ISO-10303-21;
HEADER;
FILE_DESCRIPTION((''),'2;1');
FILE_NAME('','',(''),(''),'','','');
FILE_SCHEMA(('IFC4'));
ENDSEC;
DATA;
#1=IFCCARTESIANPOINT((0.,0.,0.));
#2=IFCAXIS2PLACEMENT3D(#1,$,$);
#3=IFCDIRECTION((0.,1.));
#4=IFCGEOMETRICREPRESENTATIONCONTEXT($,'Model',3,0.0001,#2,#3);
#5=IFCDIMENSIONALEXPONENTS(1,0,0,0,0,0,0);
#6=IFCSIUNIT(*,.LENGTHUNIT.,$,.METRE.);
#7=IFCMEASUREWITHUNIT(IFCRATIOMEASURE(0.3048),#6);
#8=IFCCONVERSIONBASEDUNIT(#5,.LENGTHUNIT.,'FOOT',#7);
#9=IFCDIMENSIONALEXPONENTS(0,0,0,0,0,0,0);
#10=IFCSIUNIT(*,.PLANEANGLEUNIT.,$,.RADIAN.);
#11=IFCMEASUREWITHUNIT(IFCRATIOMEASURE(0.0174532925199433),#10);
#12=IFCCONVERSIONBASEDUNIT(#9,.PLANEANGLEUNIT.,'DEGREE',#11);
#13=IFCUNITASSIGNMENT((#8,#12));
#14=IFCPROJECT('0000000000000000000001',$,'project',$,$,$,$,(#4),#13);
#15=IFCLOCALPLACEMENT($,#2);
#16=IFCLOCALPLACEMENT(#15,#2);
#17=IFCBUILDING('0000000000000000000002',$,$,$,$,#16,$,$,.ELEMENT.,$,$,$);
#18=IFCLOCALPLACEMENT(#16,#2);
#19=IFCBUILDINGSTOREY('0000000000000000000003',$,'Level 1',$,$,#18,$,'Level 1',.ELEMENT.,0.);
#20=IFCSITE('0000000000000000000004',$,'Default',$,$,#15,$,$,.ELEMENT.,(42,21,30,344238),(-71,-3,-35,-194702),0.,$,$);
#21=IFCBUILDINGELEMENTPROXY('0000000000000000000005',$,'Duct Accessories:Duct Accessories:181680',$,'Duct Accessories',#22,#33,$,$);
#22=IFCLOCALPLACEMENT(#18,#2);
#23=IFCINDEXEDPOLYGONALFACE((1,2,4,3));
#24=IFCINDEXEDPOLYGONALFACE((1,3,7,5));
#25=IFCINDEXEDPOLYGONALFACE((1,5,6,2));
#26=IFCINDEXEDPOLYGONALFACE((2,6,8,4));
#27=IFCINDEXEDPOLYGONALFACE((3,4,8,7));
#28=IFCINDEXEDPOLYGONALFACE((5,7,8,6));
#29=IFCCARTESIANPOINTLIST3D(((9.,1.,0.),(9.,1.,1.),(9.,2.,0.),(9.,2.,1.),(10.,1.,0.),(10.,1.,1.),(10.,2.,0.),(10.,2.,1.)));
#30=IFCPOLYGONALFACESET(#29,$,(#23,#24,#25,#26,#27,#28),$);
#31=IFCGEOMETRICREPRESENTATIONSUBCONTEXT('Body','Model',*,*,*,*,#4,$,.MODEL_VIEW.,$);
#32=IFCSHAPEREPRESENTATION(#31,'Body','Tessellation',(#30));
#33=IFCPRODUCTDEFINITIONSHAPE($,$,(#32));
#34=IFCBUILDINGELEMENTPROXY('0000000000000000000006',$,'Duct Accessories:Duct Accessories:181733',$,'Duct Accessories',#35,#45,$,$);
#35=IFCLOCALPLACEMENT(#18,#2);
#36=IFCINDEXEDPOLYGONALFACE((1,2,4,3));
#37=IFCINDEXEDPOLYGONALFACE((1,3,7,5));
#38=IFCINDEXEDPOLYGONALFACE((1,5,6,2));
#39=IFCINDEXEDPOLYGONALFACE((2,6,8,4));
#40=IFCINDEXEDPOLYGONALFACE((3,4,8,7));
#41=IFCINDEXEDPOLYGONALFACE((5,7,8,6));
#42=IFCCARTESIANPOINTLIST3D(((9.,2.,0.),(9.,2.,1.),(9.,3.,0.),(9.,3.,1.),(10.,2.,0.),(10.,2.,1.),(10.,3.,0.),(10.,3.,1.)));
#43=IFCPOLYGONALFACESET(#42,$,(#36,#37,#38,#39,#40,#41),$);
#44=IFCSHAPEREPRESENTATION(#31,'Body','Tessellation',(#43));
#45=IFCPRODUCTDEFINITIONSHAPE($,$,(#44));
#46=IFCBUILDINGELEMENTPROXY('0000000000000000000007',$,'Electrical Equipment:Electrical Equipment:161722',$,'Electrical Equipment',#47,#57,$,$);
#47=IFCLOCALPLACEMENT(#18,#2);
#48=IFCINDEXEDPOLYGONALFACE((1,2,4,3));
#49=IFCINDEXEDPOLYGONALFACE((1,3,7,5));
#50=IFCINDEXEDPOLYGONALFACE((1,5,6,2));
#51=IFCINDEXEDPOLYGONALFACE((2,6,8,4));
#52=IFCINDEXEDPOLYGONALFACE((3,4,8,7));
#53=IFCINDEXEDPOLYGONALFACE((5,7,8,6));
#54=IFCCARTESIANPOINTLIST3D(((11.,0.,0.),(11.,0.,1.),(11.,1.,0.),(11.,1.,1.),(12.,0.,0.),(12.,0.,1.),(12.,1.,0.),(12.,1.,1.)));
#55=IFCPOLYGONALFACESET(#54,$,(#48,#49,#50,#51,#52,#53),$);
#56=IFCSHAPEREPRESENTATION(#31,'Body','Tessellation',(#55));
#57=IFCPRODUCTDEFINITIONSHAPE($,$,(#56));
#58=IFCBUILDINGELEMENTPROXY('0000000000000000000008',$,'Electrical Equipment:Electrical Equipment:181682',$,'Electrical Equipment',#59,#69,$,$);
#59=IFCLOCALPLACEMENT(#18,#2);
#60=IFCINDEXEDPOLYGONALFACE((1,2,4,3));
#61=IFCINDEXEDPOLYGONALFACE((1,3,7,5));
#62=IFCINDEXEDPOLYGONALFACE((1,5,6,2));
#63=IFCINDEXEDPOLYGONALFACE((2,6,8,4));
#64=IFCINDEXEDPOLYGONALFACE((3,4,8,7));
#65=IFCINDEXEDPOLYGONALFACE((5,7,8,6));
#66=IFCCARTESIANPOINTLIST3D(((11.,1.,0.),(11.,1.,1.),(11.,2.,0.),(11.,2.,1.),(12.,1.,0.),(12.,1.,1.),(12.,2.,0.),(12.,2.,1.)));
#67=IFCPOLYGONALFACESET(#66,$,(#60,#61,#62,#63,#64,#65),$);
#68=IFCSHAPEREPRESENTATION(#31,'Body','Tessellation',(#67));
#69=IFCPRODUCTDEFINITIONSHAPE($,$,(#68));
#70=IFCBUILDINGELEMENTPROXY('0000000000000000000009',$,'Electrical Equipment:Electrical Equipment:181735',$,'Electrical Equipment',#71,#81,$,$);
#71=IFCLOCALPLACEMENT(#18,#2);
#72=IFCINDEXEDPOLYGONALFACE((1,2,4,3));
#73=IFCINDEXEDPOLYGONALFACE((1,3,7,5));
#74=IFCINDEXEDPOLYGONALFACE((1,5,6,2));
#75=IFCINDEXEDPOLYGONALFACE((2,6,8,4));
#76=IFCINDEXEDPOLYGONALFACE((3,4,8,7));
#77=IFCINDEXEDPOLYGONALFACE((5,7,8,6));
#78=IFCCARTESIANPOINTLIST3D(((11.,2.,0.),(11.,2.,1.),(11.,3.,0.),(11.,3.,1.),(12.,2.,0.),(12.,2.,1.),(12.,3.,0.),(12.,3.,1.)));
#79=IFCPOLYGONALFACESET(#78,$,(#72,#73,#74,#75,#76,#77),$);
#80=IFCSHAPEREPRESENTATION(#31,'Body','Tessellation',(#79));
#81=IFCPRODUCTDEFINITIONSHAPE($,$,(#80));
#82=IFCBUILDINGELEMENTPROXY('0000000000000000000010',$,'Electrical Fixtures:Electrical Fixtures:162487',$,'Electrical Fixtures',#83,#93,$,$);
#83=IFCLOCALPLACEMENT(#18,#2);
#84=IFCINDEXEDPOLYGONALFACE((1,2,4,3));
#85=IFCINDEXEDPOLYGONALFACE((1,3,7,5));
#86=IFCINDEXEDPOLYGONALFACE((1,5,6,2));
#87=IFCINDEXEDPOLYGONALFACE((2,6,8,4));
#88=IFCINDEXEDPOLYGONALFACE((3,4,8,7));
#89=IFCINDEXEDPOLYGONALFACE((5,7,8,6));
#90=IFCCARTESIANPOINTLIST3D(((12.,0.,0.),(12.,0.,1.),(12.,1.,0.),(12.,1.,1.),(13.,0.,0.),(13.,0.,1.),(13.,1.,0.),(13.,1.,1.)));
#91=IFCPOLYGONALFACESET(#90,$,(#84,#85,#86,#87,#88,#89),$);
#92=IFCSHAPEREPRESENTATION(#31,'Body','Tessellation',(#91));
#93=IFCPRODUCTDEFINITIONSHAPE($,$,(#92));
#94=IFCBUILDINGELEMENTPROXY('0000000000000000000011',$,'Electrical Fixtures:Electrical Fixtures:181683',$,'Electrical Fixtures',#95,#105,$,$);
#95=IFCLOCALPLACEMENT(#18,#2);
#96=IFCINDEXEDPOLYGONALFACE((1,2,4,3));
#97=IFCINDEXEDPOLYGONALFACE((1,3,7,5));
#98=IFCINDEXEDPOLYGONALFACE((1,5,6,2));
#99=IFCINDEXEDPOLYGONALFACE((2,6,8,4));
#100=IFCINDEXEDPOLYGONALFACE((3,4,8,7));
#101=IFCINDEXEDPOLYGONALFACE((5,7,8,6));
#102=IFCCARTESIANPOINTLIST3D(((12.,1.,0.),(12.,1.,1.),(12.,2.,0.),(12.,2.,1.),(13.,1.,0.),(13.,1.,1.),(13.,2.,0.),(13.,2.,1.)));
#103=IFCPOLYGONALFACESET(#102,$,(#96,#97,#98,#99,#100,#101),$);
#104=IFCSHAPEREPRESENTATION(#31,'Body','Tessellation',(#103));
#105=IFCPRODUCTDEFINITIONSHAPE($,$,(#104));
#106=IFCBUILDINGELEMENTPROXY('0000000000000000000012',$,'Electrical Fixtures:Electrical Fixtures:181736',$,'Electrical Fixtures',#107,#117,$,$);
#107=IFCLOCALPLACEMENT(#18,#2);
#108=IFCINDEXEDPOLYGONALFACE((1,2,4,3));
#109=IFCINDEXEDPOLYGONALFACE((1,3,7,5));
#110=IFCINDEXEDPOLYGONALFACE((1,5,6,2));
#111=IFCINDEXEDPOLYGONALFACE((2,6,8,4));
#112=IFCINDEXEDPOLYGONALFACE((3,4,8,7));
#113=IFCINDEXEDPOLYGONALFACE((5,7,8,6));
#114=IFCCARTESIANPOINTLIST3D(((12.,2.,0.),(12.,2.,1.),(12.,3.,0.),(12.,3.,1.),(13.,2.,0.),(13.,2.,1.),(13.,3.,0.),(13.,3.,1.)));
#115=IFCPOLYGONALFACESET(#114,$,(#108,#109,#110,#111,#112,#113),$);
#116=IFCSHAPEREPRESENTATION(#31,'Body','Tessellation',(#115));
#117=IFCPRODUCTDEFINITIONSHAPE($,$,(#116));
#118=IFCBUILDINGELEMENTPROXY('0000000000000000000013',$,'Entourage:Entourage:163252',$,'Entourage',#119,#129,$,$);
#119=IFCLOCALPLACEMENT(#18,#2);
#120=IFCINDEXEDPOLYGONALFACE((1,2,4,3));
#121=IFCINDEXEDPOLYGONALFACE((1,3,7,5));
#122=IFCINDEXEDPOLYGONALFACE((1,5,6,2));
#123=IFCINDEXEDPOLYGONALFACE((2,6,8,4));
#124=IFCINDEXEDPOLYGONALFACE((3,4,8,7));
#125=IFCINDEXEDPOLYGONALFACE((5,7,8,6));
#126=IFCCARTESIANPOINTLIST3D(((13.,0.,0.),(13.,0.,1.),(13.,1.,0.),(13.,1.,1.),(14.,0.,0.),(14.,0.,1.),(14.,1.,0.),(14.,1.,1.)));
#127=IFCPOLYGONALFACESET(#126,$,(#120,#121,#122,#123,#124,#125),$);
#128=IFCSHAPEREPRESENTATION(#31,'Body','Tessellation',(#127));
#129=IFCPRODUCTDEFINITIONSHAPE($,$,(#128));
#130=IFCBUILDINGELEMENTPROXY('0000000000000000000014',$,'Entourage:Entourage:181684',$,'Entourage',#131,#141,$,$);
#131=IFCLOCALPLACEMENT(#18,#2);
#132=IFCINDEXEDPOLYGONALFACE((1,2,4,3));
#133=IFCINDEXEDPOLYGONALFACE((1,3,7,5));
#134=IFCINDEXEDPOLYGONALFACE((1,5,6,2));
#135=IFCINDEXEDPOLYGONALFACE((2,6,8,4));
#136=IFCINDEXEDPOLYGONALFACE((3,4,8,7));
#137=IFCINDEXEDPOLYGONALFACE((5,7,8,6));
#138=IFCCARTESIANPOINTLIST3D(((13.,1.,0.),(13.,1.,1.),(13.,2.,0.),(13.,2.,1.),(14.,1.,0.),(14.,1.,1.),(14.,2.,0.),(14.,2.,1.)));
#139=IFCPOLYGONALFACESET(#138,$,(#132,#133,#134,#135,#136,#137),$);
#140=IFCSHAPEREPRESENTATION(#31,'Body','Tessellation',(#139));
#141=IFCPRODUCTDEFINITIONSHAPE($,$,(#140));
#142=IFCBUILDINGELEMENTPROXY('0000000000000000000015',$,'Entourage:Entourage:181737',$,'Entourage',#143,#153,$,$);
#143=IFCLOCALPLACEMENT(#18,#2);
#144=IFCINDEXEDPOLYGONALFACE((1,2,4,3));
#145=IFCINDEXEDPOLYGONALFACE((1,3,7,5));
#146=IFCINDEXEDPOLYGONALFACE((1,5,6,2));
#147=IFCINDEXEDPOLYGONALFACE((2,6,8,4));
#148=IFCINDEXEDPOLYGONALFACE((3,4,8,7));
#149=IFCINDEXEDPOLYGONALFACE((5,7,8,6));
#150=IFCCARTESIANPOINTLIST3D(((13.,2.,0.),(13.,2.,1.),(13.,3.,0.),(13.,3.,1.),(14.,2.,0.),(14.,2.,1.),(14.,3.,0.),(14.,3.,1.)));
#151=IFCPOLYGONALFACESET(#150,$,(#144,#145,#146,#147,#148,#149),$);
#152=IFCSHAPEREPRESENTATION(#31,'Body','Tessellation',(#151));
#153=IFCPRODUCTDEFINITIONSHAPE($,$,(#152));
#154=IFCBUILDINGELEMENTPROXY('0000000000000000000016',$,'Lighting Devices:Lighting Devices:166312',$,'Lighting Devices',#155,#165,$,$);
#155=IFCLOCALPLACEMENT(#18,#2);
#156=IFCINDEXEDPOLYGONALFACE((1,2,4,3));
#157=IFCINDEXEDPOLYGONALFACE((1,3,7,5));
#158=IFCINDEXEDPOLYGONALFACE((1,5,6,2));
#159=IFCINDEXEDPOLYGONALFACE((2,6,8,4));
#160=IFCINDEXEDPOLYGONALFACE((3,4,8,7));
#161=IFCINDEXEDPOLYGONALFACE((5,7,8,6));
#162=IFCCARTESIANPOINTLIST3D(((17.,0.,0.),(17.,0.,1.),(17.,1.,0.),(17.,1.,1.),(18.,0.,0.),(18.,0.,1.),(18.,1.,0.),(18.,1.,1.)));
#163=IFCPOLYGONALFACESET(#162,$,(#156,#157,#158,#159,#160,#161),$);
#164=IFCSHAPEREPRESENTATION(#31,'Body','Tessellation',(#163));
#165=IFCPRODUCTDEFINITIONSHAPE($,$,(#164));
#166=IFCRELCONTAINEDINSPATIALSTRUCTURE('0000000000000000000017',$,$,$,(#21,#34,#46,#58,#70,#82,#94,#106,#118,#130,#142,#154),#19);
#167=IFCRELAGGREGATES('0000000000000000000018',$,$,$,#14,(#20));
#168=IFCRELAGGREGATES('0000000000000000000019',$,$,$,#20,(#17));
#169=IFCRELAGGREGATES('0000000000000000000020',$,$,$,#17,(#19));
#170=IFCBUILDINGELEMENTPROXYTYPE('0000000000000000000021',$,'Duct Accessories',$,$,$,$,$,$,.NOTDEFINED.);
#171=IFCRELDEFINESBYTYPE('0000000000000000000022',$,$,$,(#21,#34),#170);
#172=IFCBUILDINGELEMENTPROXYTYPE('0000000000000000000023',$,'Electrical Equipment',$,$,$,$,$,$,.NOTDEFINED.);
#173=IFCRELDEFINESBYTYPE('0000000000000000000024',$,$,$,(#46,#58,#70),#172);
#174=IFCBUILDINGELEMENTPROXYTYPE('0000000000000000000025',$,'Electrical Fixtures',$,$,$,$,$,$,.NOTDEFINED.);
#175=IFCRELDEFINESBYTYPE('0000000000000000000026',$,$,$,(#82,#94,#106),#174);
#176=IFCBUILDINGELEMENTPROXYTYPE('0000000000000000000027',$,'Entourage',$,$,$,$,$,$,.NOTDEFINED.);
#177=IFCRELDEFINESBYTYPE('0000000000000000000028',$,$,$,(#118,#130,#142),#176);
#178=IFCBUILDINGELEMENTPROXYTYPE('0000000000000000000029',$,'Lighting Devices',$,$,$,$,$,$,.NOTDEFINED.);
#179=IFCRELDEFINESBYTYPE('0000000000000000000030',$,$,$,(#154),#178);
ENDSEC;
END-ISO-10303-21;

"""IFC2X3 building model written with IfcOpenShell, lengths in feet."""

from ifc_helpers import new_model, entity, si_unit, converted_unit, direction, frame, frame_2d, origin, place, context, subcontext, project, spatial, rectangle, extrude, source, transform, mapped, type_object, type_shapes, element, save


model = new_model("IFC2X3")

# Units and contexts
model_context = context("Model", 3, precision=0.0001, world=origin(), true_north=direction((0.0, 1.0)))
body_context = subcontext(model_context, "Body", "Model", "MODEL_VIEW")
ifc_project = project(units=[converted_unit("LENGTHUNIT", "FOOT", entity("IfcRatioMeasure", 0.3048), si_unit("LENGTHUNIT", "METRE"), dimensions=[1, 0, 0, 0, 0, 0, 0]), converted_unit("PLANEANGLEUNIT", "DEGREE", entity("IfcRatioMeasure", 0.0174532925199433), si_unit("PLANEANGLEUNIT", "RADIAN"), dimensions=[0, 0, 0, 0, 0, 0, 0])], contexts=[model_context])

# Site, building, storey
site_placement = place(None, origin())
site = spatial("IfcSite", under=ifc_project, at=site_placement, Name="Default", CompositionType="ELEMENT", RefLatitude=(42, 21, 30, 344238), RefLongitude=(-71, -3, -35, -194702), RefElevation=0.0)
building_placement = place(site_placement, origin())
building = spatial("IfcBuilding", under=site, at=building_placement, CompositionType="ELEMENT")
storey_placement = place(building_placement, origin())
storey = spatial("IfcBuildingStorey", under=building, at=storey_placement, Name="Level 1", LongName="Level 1", CompositionType="ELEMENT", Elevation=0.0)

# Building element proxies
building_element_proxy_type_1 = type_object("IfcBuildingElementProxyType", Name="Duct Accessories", PredefinedType="NOTDEFINED")
shared_shape_1 = source(origin(), body_context, "Body", "SweptSolid", [
    extrude(rectangle(XDim=1.0, YDim=1.0, at=frame_2d((0.0, 0.0), x_axis=(1.0, 0.0))), frame((0.5, 0.5, 0.0), z_axis=(0.0, 0.0, 1.0), x_axis=(0.0, 1.0, 0.0)), (0.0, 0.0, 1.0), 1.0),
])
type_shapes(building_element_proxy_type_1, [shared_shape_1])
for number, where, name in (
    (1, (9.0, 1.0, 0.0), "Duct Accessories:Duct Accessories:181680"),
    (2, (9.0, 2.0, 0.0), "Duct Accessories:Duct Accessories:181733"),
):
    element("IfcBuildingElementProxy", number, at=place(storey_placement, frame(where)), inside=storey, type_object=building_element_proxy_type_1, Name=name, ObjectType="Duct Accessories", context=body_context, shape_type="MappedRepresentation", body=[
        mapped(shared_shape_1, transform((0.0, 0.0, 0.0), scale=1.0)),
    ])
building_element_proxy_type_2 = type_object("IfcBuildingElementProxyType", Name="Electrical Equipment", PredefinedType="NOTDEFINED")
shared_shape_2 = source(origin(), body_context, "Body", "SweptSolid", [
    extrude(rectangle(XDim=1.0, YDim=1.0, at=frame_2d((0.0, 0.0), x_axis=(1.0, 0.0))), frame((0.5, 0.5, 0.0), z_axis=(0.0, 0.0, 1.0), x_axis=(0.0, 1.0, 0.0)), (0.0, 0.0, 1.0), 1.0),
])
type_shapes(building_element_proxy_type_2, [shared_shape_2])
for number, where, name in (
    (3, (11.0, 0.0, 0.0), "Electrical Equipment:Electrical Equipment:161722"),
    (4, (11.0, 1.0, 0.0), "Electrical Equipment:Electrical Equipment:181682"),
    (5, (11.0, 2.0, 0.0), "Electrical Equipment:Electrical Equipment:181735"),
):
    element("IfcBuildingElementProxy", number, at=place(storey_placement, frame(where)), inside=storey, type_object=building_element_proxy_type_2, Name=name, ObjectType="Electrical Equipment", context=body_context, shape_type="MappedRepresentation", body=[
        mapped(shared_shape_2, transform((0.0, 0.0, 0.0), scale=1.0)),
    ])
building_element_proxy_type_3 = type_object("IfcBuildingElementProxyType", Name="Electrical Fixtures", PredefinedType="NOTDEFINED")
shared_shape_3 = source(origin(), body_context, "Body", "SweptSolid", [
    extrude(rectangle(XDim=1.0, YDim=1.0, at=frame_2d((0.0, 0.0), x_axis=(1.0, 0.0))), frame((0.5, 0.5, 0.0), z_axis=(0.0, 0.0, 1.0), x_axis=(0.0, 1.0, 0.0)), (0.0, 0.0, 1.0), 1.0),
])
type_shapes(building_element_proxy_type_3, [shared_shape_3])
for number, where, name in (
    (6, (12.0, 0.0, 0.0), "Electrical Fixtures:Electrical Fixtures:162487"),
    (7, (12.0, 1.0, 0.0), "Electrical Fixtures:Electrical Fixtures:181683"),
    (8, (12.0, 2.0, 0.0), "Electrical Fixtures:Electrical Fixtures:181736"),
):
    element("IfcBuildingElementProxy", number, at=place(storey_placement, frame(where)), inside=storey, type_object=building_element_proxy_type_3, Name=name, ObjectType="Electrical Fixtures", context=body_context, shape_type="MappedRepresentation", body=[
        mapped(shared_shape_3, transform((0.0, 0.0, 0.0), scale=1.0)),
    ])
building_element_proxy_type_4 = type_object("IfcBuildingElementProxyType", Name="Entourage", PredefinedType="NOTDEFINED")
shared_shape_4 = source(origin(), body_context, "Body", "SweptSolid", [
    extrude(rectangle(XDim=1.0, YDim=1.0, at=frame_2d((0.0, 0.0), x_axis=(1.0, 0.0))), frame((0.5, 0.5, 0.0), z_axis=(0.0, 0.0, 1.0), x_axis=(0.0, 1.0, 0.0)), (0.0, 0.0, 1.0), 1.0),
])
type_shapes(building_element_proxy_type_4, [shared_shape_4])
for number, where, name in (
    (9, (13.0, 0.0, 0.0), "Entourage:Entourage:163252"),
    (10, (13.0, 1.0, 0.0), "Entourage:Entourage:181684"),
    (11, (13.0, 2.0, 0.0), "Entourage:Entourage:181737"),
):
    element("IfcBuildingElementProxy", number, at=place(storey_placement, frame(where)), inside=storey, type_object=building_element_proxy_type_4, Name=name, ObjectType="Entourage", context=body_context, shape_type="MappedRepresentation", body=[
        mapped(shared_shape_4, transform((0.0, 0.0, 0.0), scale=1.0)),
    ])
building_element_proxy_type_5 = type_object("IfcBuildingElementProxyType", Name="Lighting Devices", PredefinedType="NOTDEFINED")
shared_shape_5 = source(origin(), body_context, "Body", "SweptSolid", [
    extrude(rectangle(XDim=1.0, YDim=1.0, at=frame_2d((0.0, 0.0), x_axis=(1.0, 0.0))), frame((0.5, 0.5, 0.0), z_axis=(0.0, 0.0, 1.0), x_axis=(0.0, 1.0, 0.0)), (0.0, 0.0, 1.0), 1.0),
])
type_shapes(building_element_proxy_type_5, [shared_shape_5])
proxy_placement = place(storey_placement, frame((17.0, 0.0, 0.0)))
element("IfcBuildingElementProxy", 12, at=proxy_placement, inside=storey, type_object=building_element_proxy_type_5, Name="Lighting Devices:Lighting Devices:166312", ObjectType="Lighting Devices", context=body_context, shape_type="MappedRepresentation", body=[
    mapped(shared_shape_5, transform((0.0, 0.0, 0.0), scale=1.0)),
])

save(model, "model.ifc")
